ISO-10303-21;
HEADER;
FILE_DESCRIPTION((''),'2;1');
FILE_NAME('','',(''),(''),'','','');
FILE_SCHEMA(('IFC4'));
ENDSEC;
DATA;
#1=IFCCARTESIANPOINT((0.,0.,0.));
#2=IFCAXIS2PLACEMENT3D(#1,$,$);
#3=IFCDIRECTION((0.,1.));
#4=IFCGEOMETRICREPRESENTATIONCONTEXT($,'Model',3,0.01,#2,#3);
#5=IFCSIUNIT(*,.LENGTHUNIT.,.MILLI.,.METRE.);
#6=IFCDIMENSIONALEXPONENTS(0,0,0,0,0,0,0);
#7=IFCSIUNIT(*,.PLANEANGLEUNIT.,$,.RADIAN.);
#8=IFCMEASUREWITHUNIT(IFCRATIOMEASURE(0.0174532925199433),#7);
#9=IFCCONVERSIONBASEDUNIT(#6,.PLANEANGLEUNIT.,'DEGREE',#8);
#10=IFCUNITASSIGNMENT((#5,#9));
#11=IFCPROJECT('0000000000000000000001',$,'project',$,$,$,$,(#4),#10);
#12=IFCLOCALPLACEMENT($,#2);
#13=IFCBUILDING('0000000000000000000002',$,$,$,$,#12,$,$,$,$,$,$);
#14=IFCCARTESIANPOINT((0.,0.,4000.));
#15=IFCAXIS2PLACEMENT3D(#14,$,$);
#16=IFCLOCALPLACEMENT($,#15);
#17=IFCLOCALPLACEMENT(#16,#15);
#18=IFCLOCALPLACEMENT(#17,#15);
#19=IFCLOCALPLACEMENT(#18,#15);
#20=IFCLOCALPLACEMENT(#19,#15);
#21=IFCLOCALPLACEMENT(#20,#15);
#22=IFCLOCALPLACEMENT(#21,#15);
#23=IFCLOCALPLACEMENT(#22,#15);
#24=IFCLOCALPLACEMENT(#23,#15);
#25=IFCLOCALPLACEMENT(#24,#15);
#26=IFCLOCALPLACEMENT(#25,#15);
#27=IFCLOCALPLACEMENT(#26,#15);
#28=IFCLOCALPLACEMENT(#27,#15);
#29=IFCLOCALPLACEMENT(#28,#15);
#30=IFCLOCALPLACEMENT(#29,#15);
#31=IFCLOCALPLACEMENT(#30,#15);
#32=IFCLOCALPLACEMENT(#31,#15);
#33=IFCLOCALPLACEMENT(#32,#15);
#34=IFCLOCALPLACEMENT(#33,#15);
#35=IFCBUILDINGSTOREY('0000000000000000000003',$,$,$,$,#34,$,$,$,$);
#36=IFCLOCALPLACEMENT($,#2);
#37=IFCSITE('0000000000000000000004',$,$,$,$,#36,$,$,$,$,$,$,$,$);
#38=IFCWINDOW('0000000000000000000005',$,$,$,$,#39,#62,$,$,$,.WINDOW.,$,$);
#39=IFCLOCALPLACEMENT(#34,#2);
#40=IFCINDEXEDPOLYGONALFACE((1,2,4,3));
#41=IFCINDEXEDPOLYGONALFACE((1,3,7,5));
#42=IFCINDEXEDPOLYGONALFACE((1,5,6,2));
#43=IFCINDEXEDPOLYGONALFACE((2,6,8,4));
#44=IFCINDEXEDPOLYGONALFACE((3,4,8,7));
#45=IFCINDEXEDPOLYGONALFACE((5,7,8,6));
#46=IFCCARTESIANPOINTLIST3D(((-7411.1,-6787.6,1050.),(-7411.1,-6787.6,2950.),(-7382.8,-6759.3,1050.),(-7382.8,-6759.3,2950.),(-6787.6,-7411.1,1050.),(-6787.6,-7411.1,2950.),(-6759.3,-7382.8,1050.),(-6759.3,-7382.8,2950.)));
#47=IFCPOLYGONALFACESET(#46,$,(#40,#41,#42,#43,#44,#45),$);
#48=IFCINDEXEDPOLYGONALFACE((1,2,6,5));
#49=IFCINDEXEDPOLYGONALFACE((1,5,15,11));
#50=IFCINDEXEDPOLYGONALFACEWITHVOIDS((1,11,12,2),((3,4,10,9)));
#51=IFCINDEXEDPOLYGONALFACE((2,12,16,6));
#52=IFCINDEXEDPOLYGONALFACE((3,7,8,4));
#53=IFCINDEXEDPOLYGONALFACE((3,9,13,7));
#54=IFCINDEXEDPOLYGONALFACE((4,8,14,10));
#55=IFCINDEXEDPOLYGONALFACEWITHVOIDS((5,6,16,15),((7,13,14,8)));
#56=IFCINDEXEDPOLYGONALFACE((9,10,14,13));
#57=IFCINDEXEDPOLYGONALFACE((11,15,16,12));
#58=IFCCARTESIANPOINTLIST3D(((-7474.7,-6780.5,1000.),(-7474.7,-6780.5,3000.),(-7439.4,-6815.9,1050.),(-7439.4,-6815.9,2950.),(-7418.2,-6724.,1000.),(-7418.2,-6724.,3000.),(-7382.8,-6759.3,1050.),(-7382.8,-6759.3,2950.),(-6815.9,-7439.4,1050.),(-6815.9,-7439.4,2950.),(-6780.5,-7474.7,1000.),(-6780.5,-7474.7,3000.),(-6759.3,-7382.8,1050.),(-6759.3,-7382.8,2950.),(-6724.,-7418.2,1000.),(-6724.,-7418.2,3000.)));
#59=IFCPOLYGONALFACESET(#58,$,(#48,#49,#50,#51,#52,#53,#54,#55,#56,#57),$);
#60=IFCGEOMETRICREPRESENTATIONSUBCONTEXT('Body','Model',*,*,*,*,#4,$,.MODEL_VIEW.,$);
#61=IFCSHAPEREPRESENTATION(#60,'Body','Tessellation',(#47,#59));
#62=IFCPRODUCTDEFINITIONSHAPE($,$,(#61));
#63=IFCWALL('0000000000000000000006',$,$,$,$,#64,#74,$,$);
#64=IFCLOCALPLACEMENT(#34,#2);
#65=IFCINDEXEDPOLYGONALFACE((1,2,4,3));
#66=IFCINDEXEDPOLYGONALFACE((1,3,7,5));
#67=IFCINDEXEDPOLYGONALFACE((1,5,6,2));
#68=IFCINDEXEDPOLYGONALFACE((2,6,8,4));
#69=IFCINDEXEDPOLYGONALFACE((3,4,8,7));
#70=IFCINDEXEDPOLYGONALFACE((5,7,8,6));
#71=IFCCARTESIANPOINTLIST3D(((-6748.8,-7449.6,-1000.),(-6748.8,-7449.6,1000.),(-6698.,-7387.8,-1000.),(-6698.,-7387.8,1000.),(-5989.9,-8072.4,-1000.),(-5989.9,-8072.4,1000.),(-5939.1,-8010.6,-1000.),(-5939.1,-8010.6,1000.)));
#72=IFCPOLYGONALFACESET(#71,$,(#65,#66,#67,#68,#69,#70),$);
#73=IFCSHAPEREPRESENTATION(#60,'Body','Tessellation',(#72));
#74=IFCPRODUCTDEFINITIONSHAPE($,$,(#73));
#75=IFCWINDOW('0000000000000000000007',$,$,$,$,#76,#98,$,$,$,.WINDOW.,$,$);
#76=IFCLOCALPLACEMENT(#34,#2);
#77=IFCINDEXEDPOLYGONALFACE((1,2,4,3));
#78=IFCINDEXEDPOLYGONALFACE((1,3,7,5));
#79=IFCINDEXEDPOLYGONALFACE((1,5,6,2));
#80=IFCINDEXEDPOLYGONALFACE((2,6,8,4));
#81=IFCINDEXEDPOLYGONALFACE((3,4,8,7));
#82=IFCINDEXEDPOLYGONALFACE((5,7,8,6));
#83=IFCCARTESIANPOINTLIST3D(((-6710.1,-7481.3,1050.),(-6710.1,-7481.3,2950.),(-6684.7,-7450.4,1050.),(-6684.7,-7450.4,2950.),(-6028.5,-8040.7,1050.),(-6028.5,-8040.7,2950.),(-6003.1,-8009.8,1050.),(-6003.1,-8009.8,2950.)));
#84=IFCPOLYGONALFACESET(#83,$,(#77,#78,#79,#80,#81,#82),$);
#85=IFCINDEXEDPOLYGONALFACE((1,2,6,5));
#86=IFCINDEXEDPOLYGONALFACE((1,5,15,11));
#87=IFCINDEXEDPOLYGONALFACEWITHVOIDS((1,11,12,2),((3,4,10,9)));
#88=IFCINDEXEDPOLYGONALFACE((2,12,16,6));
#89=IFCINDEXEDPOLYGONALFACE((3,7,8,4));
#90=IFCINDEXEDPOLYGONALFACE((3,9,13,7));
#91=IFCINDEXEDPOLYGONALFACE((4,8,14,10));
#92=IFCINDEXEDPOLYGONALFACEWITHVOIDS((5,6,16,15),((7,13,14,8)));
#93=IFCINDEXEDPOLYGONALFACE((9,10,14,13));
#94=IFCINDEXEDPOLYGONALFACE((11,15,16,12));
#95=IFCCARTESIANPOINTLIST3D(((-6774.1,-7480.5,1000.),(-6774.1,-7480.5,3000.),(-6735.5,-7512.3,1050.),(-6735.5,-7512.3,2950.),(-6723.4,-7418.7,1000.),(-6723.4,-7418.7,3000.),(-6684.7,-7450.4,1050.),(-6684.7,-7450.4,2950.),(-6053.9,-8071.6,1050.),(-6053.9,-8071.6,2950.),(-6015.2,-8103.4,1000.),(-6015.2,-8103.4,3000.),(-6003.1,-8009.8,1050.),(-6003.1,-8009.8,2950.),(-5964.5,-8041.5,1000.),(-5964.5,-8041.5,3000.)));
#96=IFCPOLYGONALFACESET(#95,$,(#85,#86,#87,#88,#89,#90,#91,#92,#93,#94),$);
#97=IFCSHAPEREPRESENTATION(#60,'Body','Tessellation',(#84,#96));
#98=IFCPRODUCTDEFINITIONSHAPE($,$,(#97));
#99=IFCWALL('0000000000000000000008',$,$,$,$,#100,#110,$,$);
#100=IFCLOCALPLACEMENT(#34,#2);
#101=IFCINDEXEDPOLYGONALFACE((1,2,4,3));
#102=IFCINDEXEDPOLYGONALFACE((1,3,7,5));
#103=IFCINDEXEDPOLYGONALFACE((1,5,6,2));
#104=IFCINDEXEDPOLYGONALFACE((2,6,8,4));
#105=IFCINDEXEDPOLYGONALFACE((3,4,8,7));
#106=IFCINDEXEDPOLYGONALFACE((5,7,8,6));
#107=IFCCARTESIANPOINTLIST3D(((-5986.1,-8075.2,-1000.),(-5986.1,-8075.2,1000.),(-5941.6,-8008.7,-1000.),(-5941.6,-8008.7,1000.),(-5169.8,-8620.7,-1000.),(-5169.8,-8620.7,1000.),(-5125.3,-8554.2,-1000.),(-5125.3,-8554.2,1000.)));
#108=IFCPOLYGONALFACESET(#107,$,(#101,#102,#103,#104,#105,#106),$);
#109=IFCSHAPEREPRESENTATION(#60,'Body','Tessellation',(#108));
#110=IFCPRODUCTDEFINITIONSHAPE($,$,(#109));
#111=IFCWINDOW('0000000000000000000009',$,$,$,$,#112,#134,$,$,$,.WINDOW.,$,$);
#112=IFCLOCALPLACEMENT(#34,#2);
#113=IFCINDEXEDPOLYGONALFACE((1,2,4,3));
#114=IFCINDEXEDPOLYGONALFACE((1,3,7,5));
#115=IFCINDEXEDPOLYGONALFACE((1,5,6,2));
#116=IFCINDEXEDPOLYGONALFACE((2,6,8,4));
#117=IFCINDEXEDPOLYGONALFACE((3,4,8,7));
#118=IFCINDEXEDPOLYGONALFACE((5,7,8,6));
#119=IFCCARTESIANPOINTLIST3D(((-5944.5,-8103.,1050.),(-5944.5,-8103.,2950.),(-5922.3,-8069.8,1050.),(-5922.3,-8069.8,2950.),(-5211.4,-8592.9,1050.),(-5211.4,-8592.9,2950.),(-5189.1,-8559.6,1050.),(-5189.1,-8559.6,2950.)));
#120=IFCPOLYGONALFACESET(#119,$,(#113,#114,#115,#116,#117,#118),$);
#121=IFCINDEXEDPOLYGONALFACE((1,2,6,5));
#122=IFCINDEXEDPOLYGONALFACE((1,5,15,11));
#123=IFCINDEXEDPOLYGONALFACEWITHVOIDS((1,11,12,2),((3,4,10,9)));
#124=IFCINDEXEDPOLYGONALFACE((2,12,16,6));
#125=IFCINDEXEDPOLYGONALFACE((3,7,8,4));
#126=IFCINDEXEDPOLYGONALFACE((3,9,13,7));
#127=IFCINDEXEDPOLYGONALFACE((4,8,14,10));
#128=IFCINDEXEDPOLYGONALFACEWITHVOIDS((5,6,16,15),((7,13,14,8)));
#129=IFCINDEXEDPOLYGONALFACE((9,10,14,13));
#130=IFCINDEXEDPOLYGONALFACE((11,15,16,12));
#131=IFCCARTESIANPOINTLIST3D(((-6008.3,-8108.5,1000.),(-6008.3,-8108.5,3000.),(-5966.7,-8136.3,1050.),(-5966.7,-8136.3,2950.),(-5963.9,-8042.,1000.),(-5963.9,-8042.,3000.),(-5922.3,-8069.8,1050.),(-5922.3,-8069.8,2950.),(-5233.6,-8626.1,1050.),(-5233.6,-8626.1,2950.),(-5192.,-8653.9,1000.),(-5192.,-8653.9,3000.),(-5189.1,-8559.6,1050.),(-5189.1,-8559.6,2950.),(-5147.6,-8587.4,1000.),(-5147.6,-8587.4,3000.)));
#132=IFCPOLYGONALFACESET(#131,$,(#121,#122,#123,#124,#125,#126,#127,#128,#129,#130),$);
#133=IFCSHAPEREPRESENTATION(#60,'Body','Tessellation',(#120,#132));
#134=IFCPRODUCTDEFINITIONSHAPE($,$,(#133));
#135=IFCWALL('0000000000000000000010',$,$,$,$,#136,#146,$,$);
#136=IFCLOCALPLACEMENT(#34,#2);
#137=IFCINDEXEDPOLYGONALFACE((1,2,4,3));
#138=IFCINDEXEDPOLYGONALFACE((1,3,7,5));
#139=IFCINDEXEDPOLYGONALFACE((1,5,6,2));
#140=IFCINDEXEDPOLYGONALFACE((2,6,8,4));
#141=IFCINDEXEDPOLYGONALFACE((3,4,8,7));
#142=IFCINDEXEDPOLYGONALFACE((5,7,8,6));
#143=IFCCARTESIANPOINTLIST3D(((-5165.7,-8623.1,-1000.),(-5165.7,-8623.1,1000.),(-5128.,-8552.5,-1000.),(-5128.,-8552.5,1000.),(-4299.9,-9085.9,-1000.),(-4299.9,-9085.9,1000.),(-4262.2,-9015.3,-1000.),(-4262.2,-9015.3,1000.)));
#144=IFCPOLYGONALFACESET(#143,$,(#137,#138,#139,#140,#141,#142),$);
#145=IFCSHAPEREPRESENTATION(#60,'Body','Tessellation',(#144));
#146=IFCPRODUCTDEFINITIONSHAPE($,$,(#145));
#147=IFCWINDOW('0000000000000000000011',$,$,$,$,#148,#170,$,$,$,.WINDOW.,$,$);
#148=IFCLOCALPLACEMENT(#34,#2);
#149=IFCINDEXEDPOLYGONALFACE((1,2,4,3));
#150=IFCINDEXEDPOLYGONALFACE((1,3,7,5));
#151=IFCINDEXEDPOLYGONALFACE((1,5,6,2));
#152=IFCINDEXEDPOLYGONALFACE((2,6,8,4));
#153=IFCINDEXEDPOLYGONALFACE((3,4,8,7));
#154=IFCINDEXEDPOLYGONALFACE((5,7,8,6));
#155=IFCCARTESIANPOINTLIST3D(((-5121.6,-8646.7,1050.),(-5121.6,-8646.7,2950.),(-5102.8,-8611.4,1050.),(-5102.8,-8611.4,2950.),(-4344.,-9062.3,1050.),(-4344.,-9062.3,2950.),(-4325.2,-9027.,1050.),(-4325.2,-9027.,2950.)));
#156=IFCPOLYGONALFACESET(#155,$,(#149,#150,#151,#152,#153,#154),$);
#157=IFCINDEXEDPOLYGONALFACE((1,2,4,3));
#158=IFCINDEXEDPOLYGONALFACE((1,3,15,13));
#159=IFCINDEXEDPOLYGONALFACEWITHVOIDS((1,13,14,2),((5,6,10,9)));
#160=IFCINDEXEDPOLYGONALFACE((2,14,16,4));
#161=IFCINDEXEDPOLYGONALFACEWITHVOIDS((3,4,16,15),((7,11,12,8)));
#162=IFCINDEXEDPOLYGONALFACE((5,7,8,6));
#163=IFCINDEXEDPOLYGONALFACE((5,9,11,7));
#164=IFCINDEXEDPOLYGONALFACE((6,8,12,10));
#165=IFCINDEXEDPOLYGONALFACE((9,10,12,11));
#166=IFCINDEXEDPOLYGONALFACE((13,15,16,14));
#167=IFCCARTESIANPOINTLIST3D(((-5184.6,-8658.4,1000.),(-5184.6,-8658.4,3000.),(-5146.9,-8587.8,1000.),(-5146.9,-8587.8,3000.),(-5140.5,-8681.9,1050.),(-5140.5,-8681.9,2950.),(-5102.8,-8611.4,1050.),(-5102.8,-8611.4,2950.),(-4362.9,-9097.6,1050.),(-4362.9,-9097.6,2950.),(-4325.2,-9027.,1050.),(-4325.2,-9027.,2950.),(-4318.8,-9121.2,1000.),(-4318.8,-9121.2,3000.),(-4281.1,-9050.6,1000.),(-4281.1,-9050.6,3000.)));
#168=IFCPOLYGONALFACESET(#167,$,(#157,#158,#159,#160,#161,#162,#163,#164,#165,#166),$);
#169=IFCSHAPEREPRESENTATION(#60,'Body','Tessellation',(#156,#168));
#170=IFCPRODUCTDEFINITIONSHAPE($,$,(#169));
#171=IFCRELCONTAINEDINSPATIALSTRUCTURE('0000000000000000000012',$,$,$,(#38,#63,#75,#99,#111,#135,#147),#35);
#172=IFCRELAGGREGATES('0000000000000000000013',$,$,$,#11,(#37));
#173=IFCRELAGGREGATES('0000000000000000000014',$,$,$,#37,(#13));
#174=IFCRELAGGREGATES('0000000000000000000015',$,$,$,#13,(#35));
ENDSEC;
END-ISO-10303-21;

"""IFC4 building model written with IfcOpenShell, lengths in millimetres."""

from ifc_helpers import new_model, entity, si_unit, converted_unit, direction, frame, origin, origin_2d, place, context, subcontext, project, spatial, rectangle, extrude, element, save


model = new_model("IFC4")

# Units and contexts
model_context = context("Model", 3, precision=0.01, world=origin(), true_north=direction((0.0, 1.0)))
body_context = subcontext(model_context, "Body", "Model", "MODEL_VIEW")
ifc_project = project(units=[si_unit("LENGTHUNIT", "METRE", prefix="MILLI"), converted_unit("PLANEANGLEUNIT", "DEGREE", entity("IfcRatioMeasure", 0.0174532925199433), si_unit("PLANEANGLEUNIT", "RADIAN"), dimensions=[0, 0, 0, 0, 0, 0, 0])], contexts=[model_context])

# Site, building, storey
site_placement = place(None, origin())
site = spatial("IfcSite", under=ifc_project, at=site_placement)
building_placement = place(None, origin())
building = spatial("IfcBuilding", under=site, at=building_placement)
placement_1 = place(None, frame((0.0, 0.0, 4000.0)))
placement_2 = place(placement_1, frame((0.0, 0.0, 4000.0)))
placement_3 = place(placement_2, frame((0.0, 0.0, 4000.0)))
placement_4 = place(placement_3, frame((0.0, 0.0, 4000.0)))
placement_5 = place(placement_4, frame((0.0, 0.0, 4000.0)))
placement_6 = place(placement_5, frame((0.0, 0.0, 4000.0)))
placement_7 = place(placement_6, frame((0.0, 0.0, 4000.0)))
placement_8 = place(placement_7, frame((0.0, 0.0, 4000.0)))
placement_9 = place(placement_8, frame((0.0, 0.0, 4000.0)))
placement_10 = place(placement_9, frame((0.0, 0.0, 4000.0)))
placement_11 = place(placement_10, frame((0.0, 0.0, 4000.0)))
placement_12 = place(placement_11, frame((0.0, 0.0, 4000.0)))
placement_13 = place(placement_12, frame((0.0, 0.0, 4000.0)))
placement_14 = place(placement_13, frame((0.0, 0.0, 4000.0)))
placement_15 = place(placement_14, frame((0.0, 0.0, 4000.0)))
placement_16 = place(placement_15, frame((0.0, 0.0, 4000.0)))
placement_17 = place(placement_16, frame((0.0, 0.0, 4000.0)))
placement_18 = place(placement_17, frame((0.0, 0.0, 4000.0)))
storey_placement = place(placement_18, frame((0.0, 0.0, 4000.0)))
storey = spatial("IfcBuildingStorey", under=building, at=storey_placement)

# Shared definitions
cartesian_point_1 = entity("IfcCartesianPoint", [-440.9, -950.0])
shared_polyline = entity("IfcPolyline", [cartesian_point_1, entity("IfcCartesianPoint", [-440.9, 950.0]), entity("IfcCartesianPoint", [-440.9, 950.0]), entity("IfcCartesianPoint", [440.9, 950.0]), entity("IfcCartesianPoint", [440.9, 950.0]), entity("IfcCartesianPoint", [440.9, -950.0]), entity("IfcCartesianPoint", [440.9, -950.0]), entity("IfcCartesianPoint", [-440.9, -950.0]), cartesian_point_1])

# Window
window_1_placement = place(storey_placement, frame((-7071.1, -7071.1, 2000.0), z_axis=(0.0, 0.0, 1.0), x_axis=(7071.06732, -7071.068304, 0.0)))
cartesian_point_2 = entity("IfcCartesianPoint", [-490.9, -1000.0])
element("IfcWindow", 1, at=window_1_placement, inside=storey, PredefinedType="WINDOW", context=body_context, shape_type="SweptSolid", body=[
    entity("IfcExtrudedAreaSolid", entity("IfcArbitraryClosedProfileDef", "AREA", None, shared_polyline), entity("IfcAxis2Placement3D", entity("IfcCartesianPoint", [0.0, 0.0, 0.0]), entity("IfcDirection", [0.0, -1.0, 0.0]), entity("IfcDirection", [1.0, 0.0, 0.0])), entity("IfcDirection", [0.0, 0.0, 1.0]), 40.0),
    entity("IfcExtrudedAreaSolid", entity("IfcArbitraryProfileDefWithVoids", "AREA", None, entity("IfcPolyline", [cartesian_point_2, entity("IfcCartesianPoint", [-490.9, 1000.0]), entity("IfcCartesianPoint", [-490.9, 1000.0]), entity("IfcCartesianPoint", [490.9, 1000.0]), entity("IfcCartesianPoint", [490.9, 1000.0]), entity("IfcCartesianPoint", [490.9, -1000.0]), entity("IfcCartesianPoint", [490.9, -1000.0]), entity("IfcCartesianPoint", [-490.9, -1000.0]), cartesian_point_2]), [shared_polyline]), entity("IfcAxis2Placement3D", entity("IfcCartesianPoint", [0.0, 0.0, 0.0]), entity("IfcDirection", [0.0, -1.0, 0.0]), entity("IfcDirection", [1.0, 0.0, 0.0])), entity("IfcDirection", [0.0, 0.0, 1.0]), 80.0),
])

# Wall
wall_1_placement = place(storey_placement, frame((-6343.9, -7730.1, -1000.0), z_axis=(0.0, 0.0, 1.0), x_axis=(7730.104346, -6343.93307, 0.0)))
element("IfcWall", 2, at=wall_1_placement, inside=storey, context=body_context, shape_type="SweptSolid", body=[
    extrude(rectangle(XDim=981.7, YDim=80.0, at=origin_2d()), origin(), (0.0, 0.0, 1.0), 2000.0),
])

# Window
window_2_placement = place(storey_placement, frame((-6343.9, -7730.1, 2000.0), z_axis=(0.0, 0.0, 1.0), x_axis=(7730.104346, -6343.93307, 0.0)))
cartesian_point_3 = entity("IfcCartesianPoint", [-490.9, -1000.0])
element("IfcWindow", 3, at=window_2_placement, inside=storey, PredefinedType="WINDOW", context=body_context, shape_type="SweptSolid", body=[
    entity("IfcExtrudedAreaSolid", entity("IfcArbitraryClosedProfileDef", "AREA", None, shared_polyline), entity("IfcAxis2Placement3D", entity("IfcCartesianPoint", [0.0, 0.0, 0.0]), entity("IfcDirection", [0.0, -1.0, 0.0]), entity("IfcDirection", [1.0, 0.0, 0.0])), entity("IfcDirection", [0.0, 0.0, 1.0]), 40.0),
    entity("IfcExtrudedAreaSolid", entity("IfcArbitraryProfileDefWithVoids", "AREA", None, entity("IfcPolyline", [cartesian_point_3, entity("IfcCartesianPoint", [-490.9, 1000.0]), entity("IfcCartesianPoint", [-490.9, 1000.0]), entity("IfcCartesianPoint", [490.9, 1000.0]), entity("IfcCartesianPoint", [490.9, 1000.0]), entity("IfcCartesianPoint", [490.9, -1000.0]), entity("IfcCartesianPoint", [490.9, -1000.0]), entity("IfcCartesianPoint", [-490.9, -1000.0]), cartesian_point_3]), [shared_polyline]), entity("IfcAxis2Placement3D", entity("IfcCartesianPoint", [0.0, 0.0, 0.0]), entity("IfcDirection", [0.0, -1.0, 0.0]), entity("IfcDirection", [1.0, 0.0, 0.0])), entity("IfcDirection", [0.0, 0.0, 1.0]), 80.0),
])

# Wall
wall_2_placement = place(storey_placement, frame((-5555.7, -8314.7, -1000.0), z_axis=(0.0, 0.0, 1.0), x_axis=(8314.694856, -5555.704226, 0.0)))
element("IfcWall", 4, at=wall_2_placement, inside=storey, context=body_context, shape_type="SweptSolid", body=[
    extrude(rectangle(XDim=981.7, YDim=80.0, at=origin_2d()), origin(), (0.0, 0.0, 1.0), 2000.0),
])

# Window
window_3_placement = place(storey_placement, frame((-5555.7, -8314.7, 2000.0), z_axis=(0.0, 0.0, 1.0), x_axis=(8314.694856, -5555.704226, 0.0)))
cartesian_point_4 = entity("IfcCartesianPoint", [-490.9, -1000.0])
element("IfcWindow", 5, at=window_3_placement, inside=storey, PredefinedType="WINDOW", context=body_context, shape_type="SweptSolid", body=[
    entity("IfcExtrudedAreaSolid", entity("IfcArbitraryClosedProfileDef", "AREA", None, shared_polyline), entity("IfcAxis2Placement3D", entity("IfcCartesianPoint", [0.0, 0.0, 0.0]), entity("IfcDirection", [0.0, -1.0, 0.0]), entity("IfcDirection", [1.0, 0.0, 0.0])), entity("IfcDirection", [0.0, 0.0, 1.0]), 40.0),
    entity("IfcExtrudedAreaSolid", entity("IfcArbitraryProfileDefWithVoids", "AREA", None, entity("IfcPolyline", [cartesian_point_4, entity("IfcCartesianPoint", [-490.9, 1000.0]), entity("IfcCartesianPoint", [-490.9, 1000.0]), entity("IfcCartesianPoint", [490.9, 1000.0]), entity("IfcCartesianPoint", [490.9, 1000.0]), entity("IfcCartesianPoint", [490.9, -1000.0]), entity("IfcCartesianPoint", [490.9, -1000.0]), entity("IfcCartesianPoint", [-490.9, -1000.0]), cartesian_point_4]), [shared_polyline]), entity("IfcAxis2Placement3D", entity("IfcCartesianPoint", [0.0, 0.0, 0.0]), entity("IfcDirection", [0.0, -1.0, 0.0]), entity("IfcDirection", [1.0, 0.0, 0.0])), entity("IfcDirection", [0.0, 0.0, 1.0]), 80.0),
])

# Wall
wall_3_placement = place(storey_placement, frame((-4714.0, -8819.2, -1000.0), z_axis=(0.0, 0.0, 1.0), x_axis=(8819.212881, -4713.966924, 0.0)))
element("IfcWall", 6, at=wall_3_placement, inside=storey, context=body_context, shape_type="SweptSolid", body=[
    extrude(rectangle(XDim=981.7, YDim=80.0, at=origin_2d()), origin(), (0.0, 0.0, 1.0), 2000.0),
])

# Window
window_4_placement = place(storey_placement, frame((-4714.0, -8819.2, 2000.0), z_axis=(0.0, 0.0, 1.0), x_axis=(8819.212881, -4713.966924, 0.0)))
cartesian_point_5 = entity("IfcCartesianPoint", [-490.9, -1000.0])
element("IfcWindow", 7, at=window_4_placement, inside=storey, PredefinedType="WINDOW", context=body_context, shape_type="SweptSolid", body=[
    entity("IfcExtrudedAreaSolid", entity("IfcArbitraryClosedProfileDef", "AREA", None, shared_polyline), entity("IfcAxis2Placement3D", entity("IfcCartesianPoint", [0.0, 0.0, 0.0]), entity("IfcDirection", [0.0, -1.0, 0.0]), entity("IfcDirection", [1.0, 0.0, 0.0])), entity("IfcDirection", [0.0, 0.0, 1.0]), 40.0),
    entity("IfcExtrudedAreaSolid", entity("IfcArbitraryProfileDefWithVoids", "AREA", None, entity("IfcPolyline", [cartesian_point_5, entity("IfcCartesianPoint", [-490.9, 1000.0]), entity("IfcCartesianPoint", [-490.9, 1000.0]), entity("IfcCartesianPoint", [490.9, 1000.0]), entity("IfcCartesianPoint", [490.9, 1000.0]), entity("IfcCartesianPoint", [490.9, -1000.0]), entity("IfcCartesianPoint", [490.9, -1000.0]), entity("IfcCartesianPoint", [-490.9, -1000.0]), cartesian_point_5]), [shared_polyline]), entity("IfcAxis2Placement3D", entity("IfcCartesianPoint", [0.0, 0.0, 0.0]), entity("IfcDirection", [0.0, -1.0, 0.0]), entity("IfcDirection", [1.0, 0.0, 0.0])), entity("IfcDirection", [0.0, 0.0, 1.0]), 80.0),
])

save(model, "model.ifc")
